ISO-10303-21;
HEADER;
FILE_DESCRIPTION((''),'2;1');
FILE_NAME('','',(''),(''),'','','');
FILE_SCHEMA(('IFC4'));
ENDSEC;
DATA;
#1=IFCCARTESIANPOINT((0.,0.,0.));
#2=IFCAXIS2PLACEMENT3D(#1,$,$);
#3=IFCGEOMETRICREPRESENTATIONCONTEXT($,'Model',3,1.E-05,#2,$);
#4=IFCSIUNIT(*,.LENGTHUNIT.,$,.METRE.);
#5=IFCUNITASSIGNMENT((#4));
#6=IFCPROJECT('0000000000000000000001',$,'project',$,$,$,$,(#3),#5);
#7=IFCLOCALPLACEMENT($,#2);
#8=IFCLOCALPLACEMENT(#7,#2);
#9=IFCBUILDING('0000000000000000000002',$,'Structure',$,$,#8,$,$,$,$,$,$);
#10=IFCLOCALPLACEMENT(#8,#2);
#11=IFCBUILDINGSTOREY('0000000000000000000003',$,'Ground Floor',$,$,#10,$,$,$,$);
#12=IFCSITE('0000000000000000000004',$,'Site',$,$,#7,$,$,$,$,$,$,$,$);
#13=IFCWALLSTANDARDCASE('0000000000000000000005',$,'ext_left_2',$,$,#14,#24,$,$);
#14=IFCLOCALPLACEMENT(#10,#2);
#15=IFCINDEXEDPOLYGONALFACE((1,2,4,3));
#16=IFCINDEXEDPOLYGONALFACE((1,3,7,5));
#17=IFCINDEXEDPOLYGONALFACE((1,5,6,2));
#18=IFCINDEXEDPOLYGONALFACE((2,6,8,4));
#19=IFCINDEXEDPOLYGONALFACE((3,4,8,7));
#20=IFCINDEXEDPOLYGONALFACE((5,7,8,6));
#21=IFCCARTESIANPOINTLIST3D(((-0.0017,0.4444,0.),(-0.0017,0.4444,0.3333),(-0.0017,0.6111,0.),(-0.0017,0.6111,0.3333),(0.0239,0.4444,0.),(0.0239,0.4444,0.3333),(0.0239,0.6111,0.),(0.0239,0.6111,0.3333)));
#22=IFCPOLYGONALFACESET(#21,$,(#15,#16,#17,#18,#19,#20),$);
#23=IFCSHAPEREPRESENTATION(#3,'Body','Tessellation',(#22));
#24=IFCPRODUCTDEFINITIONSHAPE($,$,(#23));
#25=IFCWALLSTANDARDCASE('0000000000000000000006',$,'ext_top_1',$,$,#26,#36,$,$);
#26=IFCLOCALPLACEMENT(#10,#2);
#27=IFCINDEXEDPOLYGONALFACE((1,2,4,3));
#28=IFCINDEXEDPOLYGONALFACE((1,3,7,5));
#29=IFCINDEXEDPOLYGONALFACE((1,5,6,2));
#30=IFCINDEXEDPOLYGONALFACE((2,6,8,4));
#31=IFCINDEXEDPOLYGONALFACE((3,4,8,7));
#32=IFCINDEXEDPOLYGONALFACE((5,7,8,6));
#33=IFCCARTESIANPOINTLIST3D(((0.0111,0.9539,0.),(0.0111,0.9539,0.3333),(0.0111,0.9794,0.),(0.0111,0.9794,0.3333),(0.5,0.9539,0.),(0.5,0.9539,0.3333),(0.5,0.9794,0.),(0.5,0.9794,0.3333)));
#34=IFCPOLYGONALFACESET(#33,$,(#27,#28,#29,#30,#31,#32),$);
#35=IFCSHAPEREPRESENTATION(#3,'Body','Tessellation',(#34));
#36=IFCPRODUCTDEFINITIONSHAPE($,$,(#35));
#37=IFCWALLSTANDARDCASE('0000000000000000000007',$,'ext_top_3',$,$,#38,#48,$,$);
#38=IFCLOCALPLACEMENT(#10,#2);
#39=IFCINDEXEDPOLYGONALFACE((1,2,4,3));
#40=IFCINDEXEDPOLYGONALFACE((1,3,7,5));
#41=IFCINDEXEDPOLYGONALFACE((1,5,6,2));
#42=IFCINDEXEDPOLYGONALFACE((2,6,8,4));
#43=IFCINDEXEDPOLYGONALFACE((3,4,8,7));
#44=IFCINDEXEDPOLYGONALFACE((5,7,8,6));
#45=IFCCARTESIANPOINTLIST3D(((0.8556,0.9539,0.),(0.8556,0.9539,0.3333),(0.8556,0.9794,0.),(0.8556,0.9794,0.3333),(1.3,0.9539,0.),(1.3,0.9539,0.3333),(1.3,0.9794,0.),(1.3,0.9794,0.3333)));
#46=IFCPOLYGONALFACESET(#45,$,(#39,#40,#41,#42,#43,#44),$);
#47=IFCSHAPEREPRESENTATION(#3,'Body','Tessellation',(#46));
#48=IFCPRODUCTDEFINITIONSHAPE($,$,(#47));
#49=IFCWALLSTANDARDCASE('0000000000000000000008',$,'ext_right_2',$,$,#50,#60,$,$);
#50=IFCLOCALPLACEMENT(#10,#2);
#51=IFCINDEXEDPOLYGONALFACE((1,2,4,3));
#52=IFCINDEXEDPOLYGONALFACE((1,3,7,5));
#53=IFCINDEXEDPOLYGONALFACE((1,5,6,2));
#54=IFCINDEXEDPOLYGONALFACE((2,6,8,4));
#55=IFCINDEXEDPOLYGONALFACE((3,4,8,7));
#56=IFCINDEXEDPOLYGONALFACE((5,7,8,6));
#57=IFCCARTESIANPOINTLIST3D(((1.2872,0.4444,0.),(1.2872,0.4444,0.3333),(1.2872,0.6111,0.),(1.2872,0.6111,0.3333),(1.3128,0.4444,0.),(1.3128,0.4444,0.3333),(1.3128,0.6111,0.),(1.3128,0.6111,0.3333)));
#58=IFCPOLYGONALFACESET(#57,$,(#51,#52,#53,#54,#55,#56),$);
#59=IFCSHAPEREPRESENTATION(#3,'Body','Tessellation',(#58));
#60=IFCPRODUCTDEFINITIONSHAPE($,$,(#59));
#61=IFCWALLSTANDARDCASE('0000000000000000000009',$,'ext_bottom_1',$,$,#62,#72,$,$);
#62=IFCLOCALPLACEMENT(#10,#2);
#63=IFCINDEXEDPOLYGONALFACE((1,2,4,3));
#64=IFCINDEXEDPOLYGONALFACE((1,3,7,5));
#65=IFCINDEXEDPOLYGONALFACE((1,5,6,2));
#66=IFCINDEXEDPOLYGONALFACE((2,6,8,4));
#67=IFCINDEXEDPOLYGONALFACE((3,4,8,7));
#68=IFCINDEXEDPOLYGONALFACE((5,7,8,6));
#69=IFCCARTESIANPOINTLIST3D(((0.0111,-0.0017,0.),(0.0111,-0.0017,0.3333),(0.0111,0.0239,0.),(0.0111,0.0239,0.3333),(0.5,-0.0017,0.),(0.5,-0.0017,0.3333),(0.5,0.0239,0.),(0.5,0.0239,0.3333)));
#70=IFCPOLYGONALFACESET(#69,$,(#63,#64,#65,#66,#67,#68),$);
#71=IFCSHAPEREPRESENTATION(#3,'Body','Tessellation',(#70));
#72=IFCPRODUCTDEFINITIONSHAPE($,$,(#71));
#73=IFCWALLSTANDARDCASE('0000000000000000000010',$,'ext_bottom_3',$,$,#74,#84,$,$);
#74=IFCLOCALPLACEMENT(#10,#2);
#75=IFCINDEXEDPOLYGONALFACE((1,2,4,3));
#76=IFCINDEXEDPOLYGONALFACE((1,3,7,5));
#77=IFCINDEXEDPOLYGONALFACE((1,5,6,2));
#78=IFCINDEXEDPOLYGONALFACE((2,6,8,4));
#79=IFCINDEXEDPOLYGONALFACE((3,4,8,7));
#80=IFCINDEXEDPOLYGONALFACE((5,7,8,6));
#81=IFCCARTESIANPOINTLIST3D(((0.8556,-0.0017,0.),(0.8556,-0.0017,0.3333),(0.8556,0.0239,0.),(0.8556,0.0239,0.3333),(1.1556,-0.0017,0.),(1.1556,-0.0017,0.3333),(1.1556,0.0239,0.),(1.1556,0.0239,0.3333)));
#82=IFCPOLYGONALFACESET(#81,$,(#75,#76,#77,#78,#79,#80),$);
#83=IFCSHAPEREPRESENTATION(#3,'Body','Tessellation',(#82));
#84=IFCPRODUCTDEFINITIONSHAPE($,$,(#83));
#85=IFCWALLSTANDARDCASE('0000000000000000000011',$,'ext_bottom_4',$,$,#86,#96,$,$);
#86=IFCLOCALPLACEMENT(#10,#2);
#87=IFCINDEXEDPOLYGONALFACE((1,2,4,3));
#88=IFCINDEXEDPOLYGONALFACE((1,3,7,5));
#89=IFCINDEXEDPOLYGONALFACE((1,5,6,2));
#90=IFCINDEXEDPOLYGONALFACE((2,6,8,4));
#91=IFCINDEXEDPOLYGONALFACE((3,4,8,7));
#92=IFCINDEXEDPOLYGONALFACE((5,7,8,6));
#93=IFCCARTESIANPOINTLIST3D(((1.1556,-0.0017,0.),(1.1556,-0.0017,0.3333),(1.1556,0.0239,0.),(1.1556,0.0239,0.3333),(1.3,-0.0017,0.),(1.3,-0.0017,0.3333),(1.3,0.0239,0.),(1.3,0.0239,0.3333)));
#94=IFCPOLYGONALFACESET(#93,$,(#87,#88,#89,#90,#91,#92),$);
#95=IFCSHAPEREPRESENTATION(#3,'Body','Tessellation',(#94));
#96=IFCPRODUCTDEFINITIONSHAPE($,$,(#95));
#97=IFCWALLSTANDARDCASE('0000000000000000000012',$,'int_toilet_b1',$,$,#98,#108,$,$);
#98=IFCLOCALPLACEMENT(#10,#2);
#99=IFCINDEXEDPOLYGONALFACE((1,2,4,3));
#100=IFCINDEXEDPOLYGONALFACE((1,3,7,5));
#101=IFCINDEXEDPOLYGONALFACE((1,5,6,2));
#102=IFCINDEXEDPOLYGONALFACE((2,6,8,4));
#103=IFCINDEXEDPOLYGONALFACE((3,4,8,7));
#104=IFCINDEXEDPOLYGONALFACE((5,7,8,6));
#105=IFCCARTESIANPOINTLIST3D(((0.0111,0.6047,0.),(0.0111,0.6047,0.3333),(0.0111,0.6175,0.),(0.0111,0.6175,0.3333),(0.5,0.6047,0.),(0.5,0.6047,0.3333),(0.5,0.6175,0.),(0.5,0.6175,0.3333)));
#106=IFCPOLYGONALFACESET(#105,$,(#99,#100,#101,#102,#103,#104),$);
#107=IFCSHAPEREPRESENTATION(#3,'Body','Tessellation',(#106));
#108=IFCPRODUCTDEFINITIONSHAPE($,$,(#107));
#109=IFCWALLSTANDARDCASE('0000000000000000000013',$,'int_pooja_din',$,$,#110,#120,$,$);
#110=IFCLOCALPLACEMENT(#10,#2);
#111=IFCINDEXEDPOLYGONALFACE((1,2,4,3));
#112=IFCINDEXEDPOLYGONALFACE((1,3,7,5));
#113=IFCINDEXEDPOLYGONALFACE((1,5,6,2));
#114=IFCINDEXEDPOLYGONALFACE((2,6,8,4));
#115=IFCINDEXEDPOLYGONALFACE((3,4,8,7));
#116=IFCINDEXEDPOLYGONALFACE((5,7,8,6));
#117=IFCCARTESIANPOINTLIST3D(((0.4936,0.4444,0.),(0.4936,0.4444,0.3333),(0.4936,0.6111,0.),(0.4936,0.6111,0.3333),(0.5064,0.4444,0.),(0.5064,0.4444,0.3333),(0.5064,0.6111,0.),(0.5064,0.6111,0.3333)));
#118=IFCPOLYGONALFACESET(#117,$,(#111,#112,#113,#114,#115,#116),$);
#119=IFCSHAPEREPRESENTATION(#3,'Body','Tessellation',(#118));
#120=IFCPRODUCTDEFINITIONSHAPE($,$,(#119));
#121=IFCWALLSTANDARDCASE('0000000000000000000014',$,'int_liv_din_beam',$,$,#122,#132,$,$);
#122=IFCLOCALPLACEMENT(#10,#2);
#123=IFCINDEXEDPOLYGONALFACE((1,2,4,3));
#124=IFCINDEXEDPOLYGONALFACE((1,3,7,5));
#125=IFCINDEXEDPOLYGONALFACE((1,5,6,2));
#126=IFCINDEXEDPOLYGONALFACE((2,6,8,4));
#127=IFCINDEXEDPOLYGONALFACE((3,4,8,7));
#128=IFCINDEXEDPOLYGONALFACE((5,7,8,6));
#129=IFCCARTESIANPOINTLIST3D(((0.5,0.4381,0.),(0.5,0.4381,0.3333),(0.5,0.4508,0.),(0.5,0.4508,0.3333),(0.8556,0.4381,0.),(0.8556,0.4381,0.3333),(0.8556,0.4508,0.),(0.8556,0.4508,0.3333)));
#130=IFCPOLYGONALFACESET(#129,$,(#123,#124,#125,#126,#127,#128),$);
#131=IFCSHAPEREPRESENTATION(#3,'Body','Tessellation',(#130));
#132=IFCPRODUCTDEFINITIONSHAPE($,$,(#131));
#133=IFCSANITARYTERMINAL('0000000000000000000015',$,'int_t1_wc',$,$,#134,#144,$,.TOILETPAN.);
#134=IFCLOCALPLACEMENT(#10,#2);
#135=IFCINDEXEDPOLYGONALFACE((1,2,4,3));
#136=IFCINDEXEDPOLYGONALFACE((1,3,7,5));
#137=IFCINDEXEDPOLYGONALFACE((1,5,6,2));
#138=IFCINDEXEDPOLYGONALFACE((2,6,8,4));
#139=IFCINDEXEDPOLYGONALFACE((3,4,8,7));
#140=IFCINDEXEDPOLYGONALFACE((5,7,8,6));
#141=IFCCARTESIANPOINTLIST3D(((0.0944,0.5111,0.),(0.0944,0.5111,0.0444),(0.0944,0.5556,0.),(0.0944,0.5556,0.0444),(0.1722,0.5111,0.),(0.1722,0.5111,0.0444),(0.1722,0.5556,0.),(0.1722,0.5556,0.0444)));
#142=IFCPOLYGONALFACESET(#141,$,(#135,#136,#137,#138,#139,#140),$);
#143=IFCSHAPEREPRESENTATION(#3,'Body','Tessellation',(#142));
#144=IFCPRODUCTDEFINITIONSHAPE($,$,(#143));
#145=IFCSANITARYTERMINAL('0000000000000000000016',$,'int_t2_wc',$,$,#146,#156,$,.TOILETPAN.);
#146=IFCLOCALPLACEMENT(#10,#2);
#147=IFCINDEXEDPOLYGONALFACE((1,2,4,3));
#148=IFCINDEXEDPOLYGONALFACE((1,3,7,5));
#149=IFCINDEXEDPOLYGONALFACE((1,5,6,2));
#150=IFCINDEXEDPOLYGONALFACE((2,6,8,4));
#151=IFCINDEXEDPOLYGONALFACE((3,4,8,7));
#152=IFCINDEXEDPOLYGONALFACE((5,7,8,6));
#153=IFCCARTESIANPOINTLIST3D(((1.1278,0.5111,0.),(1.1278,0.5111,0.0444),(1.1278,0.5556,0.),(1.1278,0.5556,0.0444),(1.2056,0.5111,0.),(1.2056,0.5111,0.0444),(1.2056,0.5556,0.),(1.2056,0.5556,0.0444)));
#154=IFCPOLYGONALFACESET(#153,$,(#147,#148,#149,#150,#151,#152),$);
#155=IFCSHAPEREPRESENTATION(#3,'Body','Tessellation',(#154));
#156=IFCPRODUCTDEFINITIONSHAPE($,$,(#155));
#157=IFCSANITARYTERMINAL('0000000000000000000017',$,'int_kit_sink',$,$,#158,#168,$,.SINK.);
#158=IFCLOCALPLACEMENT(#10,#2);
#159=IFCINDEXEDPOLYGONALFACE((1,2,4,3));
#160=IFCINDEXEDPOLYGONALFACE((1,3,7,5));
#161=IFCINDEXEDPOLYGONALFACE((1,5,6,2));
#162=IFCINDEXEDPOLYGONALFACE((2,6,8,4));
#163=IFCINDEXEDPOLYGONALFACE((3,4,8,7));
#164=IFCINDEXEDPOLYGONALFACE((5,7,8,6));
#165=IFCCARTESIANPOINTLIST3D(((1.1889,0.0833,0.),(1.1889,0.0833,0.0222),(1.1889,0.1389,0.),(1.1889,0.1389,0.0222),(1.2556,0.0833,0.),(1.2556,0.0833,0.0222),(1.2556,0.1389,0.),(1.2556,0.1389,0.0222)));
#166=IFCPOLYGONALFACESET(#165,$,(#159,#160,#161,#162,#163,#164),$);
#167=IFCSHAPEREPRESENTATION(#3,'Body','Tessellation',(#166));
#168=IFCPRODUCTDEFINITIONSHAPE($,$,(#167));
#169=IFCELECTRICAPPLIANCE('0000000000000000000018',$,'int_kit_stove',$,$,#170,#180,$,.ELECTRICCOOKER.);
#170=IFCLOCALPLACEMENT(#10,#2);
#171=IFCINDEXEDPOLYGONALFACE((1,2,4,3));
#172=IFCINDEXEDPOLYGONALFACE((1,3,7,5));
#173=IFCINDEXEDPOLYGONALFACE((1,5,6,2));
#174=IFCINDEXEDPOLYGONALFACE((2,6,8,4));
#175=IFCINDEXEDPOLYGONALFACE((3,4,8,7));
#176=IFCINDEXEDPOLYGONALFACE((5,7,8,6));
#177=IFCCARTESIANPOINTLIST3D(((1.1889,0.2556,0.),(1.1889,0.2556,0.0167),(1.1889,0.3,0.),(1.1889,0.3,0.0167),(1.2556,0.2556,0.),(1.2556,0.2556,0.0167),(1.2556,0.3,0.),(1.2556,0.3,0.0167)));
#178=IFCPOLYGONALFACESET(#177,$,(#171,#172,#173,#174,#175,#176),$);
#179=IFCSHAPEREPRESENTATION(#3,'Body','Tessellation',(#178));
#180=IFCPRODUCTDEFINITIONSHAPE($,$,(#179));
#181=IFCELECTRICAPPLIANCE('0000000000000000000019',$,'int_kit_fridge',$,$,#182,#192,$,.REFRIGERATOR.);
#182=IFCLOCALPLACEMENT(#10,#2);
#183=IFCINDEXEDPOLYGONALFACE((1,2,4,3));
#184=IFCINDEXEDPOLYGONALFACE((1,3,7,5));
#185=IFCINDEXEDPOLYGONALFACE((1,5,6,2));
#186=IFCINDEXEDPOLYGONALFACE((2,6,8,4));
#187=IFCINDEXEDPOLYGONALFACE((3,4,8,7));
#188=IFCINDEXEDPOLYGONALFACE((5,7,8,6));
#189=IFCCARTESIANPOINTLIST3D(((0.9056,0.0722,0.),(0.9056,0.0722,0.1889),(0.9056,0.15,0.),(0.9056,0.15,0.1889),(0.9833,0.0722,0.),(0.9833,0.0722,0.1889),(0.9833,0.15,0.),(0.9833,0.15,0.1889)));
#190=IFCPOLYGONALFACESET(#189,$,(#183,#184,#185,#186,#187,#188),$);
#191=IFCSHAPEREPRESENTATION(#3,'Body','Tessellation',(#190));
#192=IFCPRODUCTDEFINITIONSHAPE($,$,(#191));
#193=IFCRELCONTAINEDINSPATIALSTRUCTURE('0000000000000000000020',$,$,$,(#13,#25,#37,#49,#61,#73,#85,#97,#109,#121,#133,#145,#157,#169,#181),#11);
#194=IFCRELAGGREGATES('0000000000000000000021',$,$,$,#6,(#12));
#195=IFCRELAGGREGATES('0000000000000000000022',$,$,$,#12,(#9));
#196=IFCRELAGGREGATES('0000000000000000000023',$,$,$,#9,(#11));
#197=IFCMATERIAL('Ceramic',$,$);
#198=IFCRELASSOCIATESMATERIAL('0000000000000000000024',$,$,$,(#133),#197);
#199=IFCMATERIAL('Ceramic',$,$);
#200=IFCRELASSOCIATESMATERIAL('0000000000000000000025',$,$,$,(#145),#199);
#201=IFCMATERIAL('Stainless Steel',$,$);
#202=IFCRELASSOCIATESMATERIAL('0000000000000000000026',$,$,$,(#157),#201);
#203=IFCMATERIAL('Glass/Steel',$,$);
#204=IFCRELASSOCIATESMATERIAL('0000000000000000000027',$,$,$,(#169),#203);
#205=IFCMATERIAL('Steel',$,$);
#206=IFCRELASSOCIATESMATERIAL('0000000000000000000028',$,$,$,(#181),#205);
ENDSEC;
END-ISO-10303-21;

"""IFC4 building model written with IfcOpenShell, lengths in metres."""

from ifc_helpers import new_model, si_unit, frame, origin, place, context, project, spatial, polyline, outline, extrude, material, element, save


model = new_model("IFC4")

# Units and contexts
model_context = context("Model", 3, precision=1e-05, world=origin())
ifc_project = project(units=[si_unit("LENGTHUNIT", "METRE")], contexts=[model_context])

# Site, building, storey
site_placement = place(None, origin())
site = spatial("IfcSite", under=ifc_project, at=site_placement, Name="Site")
building_placement = place(site_placement, origin())
building = spatial("IfcBuilding", under=site, at=building_placement, Name="Structure")
storey_placement = place(building_placement, origin())
storey = spatial("IfcBuildingStorey", under=building, at=storey_placement, Name="Ground Floor")

# Walls
wall_1_placement = place(storey_placement, frame((0.0111, 0.4444, 0.0), x_axis=(0.0, 1.0, 0.0)))
element("IfcWallStandardCase", 1, at=wall_1_placement, inside=storey, Name="ext_left_2", context=model_context, shape_type="SweptSolid", body=[
    extrude(outline(polyline([(0.0, -0.0128), (0.1667, -0.0128), (0.1667, 0.0128), (0.0, 0.0128), (0.0, -0.0128)])), origin(), (0.0, 0.0, 1.0), 0.3333),
])
wall_2_placement = place(storey_placement, frame((0.0111, 0.9667, 0.0), x_axis=(1.0, 0.0, 0.0)))
element("IfcWallStandardCase", 2, at=wall_2_placement, inside=storey, Name="ext_top_1", context=model_context, shape_type="SweptSolid", body=[
    extrude(outline(polyline([(0.0, -0.0128), (0.4889, -0.0128), (0.4889, 0.0128), (0.0, 0.0128), (0.0, -0.0128)])), origin(), (0.0, 0.0, 1.0), 0.3333),
])
wall_3_placement = place(storey_placement, frame((0.8556, 0.9667, 0.0), x_axis=(1.0, 0.0, 0.0)))
element("IfcWallStandardCase", 3, at=wall_3_placement, inside=storey, Name="ext_top_3", context=model_context, shape_type="SweptSolid", body=[
    extrude(outline(polyline([(0.0, -0.0128), (0.4444, -0.0128), (0.4444, 0.0128), (0.0, 0.0128), (0.0, -0.0128)])), origin(), (0.0, 0.0, 1.0), 0.3333),
])
wall_4_placement = place(storey_placement, frame((1.3, 0.6111, 0.0), x_axis=(0.0, -1.0, 0.0)))
element("IfcWallStandardCase", 4, at=wall_4_placement, inside=storey, Name="ext_right_2", context=model_context, shape_type="SweptSolid", body=[
    extrude(outline(polyline([(0.0, -0.0128), (0.1667, -0.0128), (0.1667, 0.0128), (0.0, 0.0128), (0.0, -0.0128)])), origin(), (0.0, 0.0, 1.0), 0.3333),
])
wall_5_placement = place(storey_placement, frame((0.0111, 0.0111, 0.0), x_axis=(1.0, 0.0, 0.0)))
element("IfcWallStandardCase", 5, at=wall_5_placement, inside=storey, Name="ext_bottom_1", context=model_context, shape_type="SweptSolid", body=[
    extrude(outline(polyline([(0.0, -0.0128), (0.4889, -0.0128), (0.4889, 0.0128), (0.0, 0.0128), (0.0, -0.0128)])), origin(), (0.0, 0.0, 1.0), 0.3333),
])
wall_6_placement = place(storey_placement, frame((0.8556, 0.0111, 0.0), x_axis=(1.0, 0.0, 0.0)))
element("IfcWallStandardCase", 6, at=wall_6_placement, inside=storey, Name="ext_bottom_3", context=model_context, shape_type="SweptSolid", body=[
    extrude(outline(polyline([(0.0, -0.0128), (0.3, -0.0128), (0.3, 0.0128), (0.0, 0.0128), (0.0, -0.0128)])), origin(), (0.0, 0.0, 1.0), 0.3333),
])
wall_7_placement = place(storey_placement, frame((1.1556, 0.0111, 0.0), x_axis=(1.0, 0.0, 0.0)))
element("IfcWallStandardCase", 7, at=wall_7_placement, inside=storey, Name="ext_bottom_4", context=model_context, shape_type="SweptSolid", body=[
    extrude(outline(polyline([(0.0, -0.0128), (0.1444, -0.0128), (0.1444, 0.0128), (0.0, 0.0128), (0.0, -0.0128)])), origin(), (0.0, 0.0, 1.0), 0.3333),
])
wall_8_placement = place(storey_placement, frame((0.0111, 0.6111, 0.0), x_axis=(1.0, 0.0, 0.0)))
element("IfcWallStandardCase", 8, at=wall_8_placement, inside=storey, Name="int_toilet_b1", context=model_context, shape_type="SweptSolid", body=[
    extrude(outline(polyline([(0.0, -0.0064), (0.4889, -0.0064), (0.4889, 0.0064), (0.0, 0.0064), (0.0, -0.0064)])), origin(), (0.0, 0.0, 1.0), 0.3333),
])
wall_9_placement = place(storey_placement, frame((0.5, 0.4444, 0.0), x_axis=(0.0, 1.0, 0.0)))
element("IfcWallStandardCase", 9, at=wall_9_placement, inside=storey, Name="int_pooja_din", context=model_context, shape_type="SweptSolid", body=[
    extrude(outline(polyline([(0.0, -0.0064), (0.1667, -0.0064), (0.1667, 0.0064), (0.0, 0.0064), (0.0, -0.0064)])), origin(), (0.0, 0.0, 1.0), 0.3333),
])
wall_10_placement = place(storey_placement, frame((0.5, 0.4444, 0.0), x_axis=(1.0, 0.0, 0.0)))
element("IfcWallStandardCase", 10, at=wall_10_placement, inside=storey, Name="int_liv_din_beam", context=model_context, shape_type="SweptSolid", body=[
    extrude(outline(polyline([(0.0, -0.0064), (0.3556, -0.0064), (0.3556, 0.0064), (0.0, 0.0064), (0.0, -0.0064)])), origin(), (0.0, 0.0, 1.0), 0.3333),
])

# Sanitary terminals
ifc_material_1 = material(Name="Ceramic")
sanitary_terminal_1_placement = place(storey_placement, frame((0.1333, 0.5333, 0.0)))
element("IfcSanitaryTerminal", 11, at=sanitary_terminal_1_placement, inside=storey, material=ifc_material_1, Name="int_t1_wc", PredefinedType="TOILETPAN", context=model_context, shape_type="SweptSolid", body=[
    extrude(outline(polyline([(-0.0389, -0.0222), (0.0389, -0.0222), (0.0389, 0.0222), (-0.0389, 0.0222), (-0.0389, -0.0222)])), origin(), (0.0, 0.0, 1.0), 0.0444),
])
ifc_material_2 = material(Name="Ceramic")
sanitary_terminal_2_placement = place(storey_placement, frame((1.1667, 0.5333, 0.0)))
element("IfcSanitaryTerminal", 12, at=sanitary_terminal_2_placement, inside=storey, material=ifc_material_2, Name="int_t2_wc", PredefinedType="TOILETPAN", context=model_context, shape_type="SweptSolid", body=[
    extrude(outline(polyline([(-0.0389, -0.0222), (0.0389, -0.0222), (0.0389, 0.0222), (-0.0389, 0.0222), (-0.0389, -0.0222)])), origin(), (0.0, 0.0, 1.0), 0.0444),
])
ifc_material_3 = material(Name="Stainless Steel")
sanitary_terminal_3_placement = place(storey_placement, frame((1.2222, 0.1111, 0.0)))
element("IfcSanitaryTerminal", 13, at=sanitary_terminal_3_placement, inside=storey, material=ifc_material_3, Name="int_kit_sink", PredefinedType="SINK", context=model_context, shape_type="SweptSolid", body=[
    extrude(outline(polyline([(-0.0333, -0.0278), (0.0333, -0.0278), (0.0333, 0.0278), (-0.0333, 0.0278), (-0.0333, -0.0278)])), origin(), (0.0, 0.0, 1.0), 0.0222),
])

# Electric appliances
ifc_material_4 = material(Name="Glass/Steel")
electric_appliance_1_placement = place(storey_placement, frame((1.2222, 0.2778, 0.0)))
element("IfcElectricAppliance", 14, at=electric_appliance_1_placement, inside=storey, material=ifc_material_4, Name="int_kit_stove", PredefinedType="ELECTRICCOOKER", context=model_context, shape_type="SweptSolid", body=[
    extrude(outline(polyline([(-0.0333, -0.0222), (0.0333, -0.0222), (0.0333, 0.0222), (-0.0333, 0.0222), (-0.0333, -0.0222)])), origin(), (0.0, 0.0, 1.0), 0.0167),
])
ifc_material_5 = material(Name="Steel")
electric_appliance_2_placement = place(storey_placement, frame((0.9444, 0.1111, 0.0)))
element("IfcElectricAppliance", 15, at=electric_appliance_2_placement, inside=storey, material=ifc_material_5, Name="int_kit_fridge", PredefinedType="REFRIGERATOR", context=model_context, shape_type="SweptSolid", body=[
    extrude(outline(polyline([(-0.0389, -0.0389), (0.0389, -0.0389), (0.0389, 0.0389), (-0.0389, 0.0389), (-0.0389, -0.0389)])), origin(), (0.0, 0.0, 1.0), 0.1889),
])

save(model, "model.ifc")
